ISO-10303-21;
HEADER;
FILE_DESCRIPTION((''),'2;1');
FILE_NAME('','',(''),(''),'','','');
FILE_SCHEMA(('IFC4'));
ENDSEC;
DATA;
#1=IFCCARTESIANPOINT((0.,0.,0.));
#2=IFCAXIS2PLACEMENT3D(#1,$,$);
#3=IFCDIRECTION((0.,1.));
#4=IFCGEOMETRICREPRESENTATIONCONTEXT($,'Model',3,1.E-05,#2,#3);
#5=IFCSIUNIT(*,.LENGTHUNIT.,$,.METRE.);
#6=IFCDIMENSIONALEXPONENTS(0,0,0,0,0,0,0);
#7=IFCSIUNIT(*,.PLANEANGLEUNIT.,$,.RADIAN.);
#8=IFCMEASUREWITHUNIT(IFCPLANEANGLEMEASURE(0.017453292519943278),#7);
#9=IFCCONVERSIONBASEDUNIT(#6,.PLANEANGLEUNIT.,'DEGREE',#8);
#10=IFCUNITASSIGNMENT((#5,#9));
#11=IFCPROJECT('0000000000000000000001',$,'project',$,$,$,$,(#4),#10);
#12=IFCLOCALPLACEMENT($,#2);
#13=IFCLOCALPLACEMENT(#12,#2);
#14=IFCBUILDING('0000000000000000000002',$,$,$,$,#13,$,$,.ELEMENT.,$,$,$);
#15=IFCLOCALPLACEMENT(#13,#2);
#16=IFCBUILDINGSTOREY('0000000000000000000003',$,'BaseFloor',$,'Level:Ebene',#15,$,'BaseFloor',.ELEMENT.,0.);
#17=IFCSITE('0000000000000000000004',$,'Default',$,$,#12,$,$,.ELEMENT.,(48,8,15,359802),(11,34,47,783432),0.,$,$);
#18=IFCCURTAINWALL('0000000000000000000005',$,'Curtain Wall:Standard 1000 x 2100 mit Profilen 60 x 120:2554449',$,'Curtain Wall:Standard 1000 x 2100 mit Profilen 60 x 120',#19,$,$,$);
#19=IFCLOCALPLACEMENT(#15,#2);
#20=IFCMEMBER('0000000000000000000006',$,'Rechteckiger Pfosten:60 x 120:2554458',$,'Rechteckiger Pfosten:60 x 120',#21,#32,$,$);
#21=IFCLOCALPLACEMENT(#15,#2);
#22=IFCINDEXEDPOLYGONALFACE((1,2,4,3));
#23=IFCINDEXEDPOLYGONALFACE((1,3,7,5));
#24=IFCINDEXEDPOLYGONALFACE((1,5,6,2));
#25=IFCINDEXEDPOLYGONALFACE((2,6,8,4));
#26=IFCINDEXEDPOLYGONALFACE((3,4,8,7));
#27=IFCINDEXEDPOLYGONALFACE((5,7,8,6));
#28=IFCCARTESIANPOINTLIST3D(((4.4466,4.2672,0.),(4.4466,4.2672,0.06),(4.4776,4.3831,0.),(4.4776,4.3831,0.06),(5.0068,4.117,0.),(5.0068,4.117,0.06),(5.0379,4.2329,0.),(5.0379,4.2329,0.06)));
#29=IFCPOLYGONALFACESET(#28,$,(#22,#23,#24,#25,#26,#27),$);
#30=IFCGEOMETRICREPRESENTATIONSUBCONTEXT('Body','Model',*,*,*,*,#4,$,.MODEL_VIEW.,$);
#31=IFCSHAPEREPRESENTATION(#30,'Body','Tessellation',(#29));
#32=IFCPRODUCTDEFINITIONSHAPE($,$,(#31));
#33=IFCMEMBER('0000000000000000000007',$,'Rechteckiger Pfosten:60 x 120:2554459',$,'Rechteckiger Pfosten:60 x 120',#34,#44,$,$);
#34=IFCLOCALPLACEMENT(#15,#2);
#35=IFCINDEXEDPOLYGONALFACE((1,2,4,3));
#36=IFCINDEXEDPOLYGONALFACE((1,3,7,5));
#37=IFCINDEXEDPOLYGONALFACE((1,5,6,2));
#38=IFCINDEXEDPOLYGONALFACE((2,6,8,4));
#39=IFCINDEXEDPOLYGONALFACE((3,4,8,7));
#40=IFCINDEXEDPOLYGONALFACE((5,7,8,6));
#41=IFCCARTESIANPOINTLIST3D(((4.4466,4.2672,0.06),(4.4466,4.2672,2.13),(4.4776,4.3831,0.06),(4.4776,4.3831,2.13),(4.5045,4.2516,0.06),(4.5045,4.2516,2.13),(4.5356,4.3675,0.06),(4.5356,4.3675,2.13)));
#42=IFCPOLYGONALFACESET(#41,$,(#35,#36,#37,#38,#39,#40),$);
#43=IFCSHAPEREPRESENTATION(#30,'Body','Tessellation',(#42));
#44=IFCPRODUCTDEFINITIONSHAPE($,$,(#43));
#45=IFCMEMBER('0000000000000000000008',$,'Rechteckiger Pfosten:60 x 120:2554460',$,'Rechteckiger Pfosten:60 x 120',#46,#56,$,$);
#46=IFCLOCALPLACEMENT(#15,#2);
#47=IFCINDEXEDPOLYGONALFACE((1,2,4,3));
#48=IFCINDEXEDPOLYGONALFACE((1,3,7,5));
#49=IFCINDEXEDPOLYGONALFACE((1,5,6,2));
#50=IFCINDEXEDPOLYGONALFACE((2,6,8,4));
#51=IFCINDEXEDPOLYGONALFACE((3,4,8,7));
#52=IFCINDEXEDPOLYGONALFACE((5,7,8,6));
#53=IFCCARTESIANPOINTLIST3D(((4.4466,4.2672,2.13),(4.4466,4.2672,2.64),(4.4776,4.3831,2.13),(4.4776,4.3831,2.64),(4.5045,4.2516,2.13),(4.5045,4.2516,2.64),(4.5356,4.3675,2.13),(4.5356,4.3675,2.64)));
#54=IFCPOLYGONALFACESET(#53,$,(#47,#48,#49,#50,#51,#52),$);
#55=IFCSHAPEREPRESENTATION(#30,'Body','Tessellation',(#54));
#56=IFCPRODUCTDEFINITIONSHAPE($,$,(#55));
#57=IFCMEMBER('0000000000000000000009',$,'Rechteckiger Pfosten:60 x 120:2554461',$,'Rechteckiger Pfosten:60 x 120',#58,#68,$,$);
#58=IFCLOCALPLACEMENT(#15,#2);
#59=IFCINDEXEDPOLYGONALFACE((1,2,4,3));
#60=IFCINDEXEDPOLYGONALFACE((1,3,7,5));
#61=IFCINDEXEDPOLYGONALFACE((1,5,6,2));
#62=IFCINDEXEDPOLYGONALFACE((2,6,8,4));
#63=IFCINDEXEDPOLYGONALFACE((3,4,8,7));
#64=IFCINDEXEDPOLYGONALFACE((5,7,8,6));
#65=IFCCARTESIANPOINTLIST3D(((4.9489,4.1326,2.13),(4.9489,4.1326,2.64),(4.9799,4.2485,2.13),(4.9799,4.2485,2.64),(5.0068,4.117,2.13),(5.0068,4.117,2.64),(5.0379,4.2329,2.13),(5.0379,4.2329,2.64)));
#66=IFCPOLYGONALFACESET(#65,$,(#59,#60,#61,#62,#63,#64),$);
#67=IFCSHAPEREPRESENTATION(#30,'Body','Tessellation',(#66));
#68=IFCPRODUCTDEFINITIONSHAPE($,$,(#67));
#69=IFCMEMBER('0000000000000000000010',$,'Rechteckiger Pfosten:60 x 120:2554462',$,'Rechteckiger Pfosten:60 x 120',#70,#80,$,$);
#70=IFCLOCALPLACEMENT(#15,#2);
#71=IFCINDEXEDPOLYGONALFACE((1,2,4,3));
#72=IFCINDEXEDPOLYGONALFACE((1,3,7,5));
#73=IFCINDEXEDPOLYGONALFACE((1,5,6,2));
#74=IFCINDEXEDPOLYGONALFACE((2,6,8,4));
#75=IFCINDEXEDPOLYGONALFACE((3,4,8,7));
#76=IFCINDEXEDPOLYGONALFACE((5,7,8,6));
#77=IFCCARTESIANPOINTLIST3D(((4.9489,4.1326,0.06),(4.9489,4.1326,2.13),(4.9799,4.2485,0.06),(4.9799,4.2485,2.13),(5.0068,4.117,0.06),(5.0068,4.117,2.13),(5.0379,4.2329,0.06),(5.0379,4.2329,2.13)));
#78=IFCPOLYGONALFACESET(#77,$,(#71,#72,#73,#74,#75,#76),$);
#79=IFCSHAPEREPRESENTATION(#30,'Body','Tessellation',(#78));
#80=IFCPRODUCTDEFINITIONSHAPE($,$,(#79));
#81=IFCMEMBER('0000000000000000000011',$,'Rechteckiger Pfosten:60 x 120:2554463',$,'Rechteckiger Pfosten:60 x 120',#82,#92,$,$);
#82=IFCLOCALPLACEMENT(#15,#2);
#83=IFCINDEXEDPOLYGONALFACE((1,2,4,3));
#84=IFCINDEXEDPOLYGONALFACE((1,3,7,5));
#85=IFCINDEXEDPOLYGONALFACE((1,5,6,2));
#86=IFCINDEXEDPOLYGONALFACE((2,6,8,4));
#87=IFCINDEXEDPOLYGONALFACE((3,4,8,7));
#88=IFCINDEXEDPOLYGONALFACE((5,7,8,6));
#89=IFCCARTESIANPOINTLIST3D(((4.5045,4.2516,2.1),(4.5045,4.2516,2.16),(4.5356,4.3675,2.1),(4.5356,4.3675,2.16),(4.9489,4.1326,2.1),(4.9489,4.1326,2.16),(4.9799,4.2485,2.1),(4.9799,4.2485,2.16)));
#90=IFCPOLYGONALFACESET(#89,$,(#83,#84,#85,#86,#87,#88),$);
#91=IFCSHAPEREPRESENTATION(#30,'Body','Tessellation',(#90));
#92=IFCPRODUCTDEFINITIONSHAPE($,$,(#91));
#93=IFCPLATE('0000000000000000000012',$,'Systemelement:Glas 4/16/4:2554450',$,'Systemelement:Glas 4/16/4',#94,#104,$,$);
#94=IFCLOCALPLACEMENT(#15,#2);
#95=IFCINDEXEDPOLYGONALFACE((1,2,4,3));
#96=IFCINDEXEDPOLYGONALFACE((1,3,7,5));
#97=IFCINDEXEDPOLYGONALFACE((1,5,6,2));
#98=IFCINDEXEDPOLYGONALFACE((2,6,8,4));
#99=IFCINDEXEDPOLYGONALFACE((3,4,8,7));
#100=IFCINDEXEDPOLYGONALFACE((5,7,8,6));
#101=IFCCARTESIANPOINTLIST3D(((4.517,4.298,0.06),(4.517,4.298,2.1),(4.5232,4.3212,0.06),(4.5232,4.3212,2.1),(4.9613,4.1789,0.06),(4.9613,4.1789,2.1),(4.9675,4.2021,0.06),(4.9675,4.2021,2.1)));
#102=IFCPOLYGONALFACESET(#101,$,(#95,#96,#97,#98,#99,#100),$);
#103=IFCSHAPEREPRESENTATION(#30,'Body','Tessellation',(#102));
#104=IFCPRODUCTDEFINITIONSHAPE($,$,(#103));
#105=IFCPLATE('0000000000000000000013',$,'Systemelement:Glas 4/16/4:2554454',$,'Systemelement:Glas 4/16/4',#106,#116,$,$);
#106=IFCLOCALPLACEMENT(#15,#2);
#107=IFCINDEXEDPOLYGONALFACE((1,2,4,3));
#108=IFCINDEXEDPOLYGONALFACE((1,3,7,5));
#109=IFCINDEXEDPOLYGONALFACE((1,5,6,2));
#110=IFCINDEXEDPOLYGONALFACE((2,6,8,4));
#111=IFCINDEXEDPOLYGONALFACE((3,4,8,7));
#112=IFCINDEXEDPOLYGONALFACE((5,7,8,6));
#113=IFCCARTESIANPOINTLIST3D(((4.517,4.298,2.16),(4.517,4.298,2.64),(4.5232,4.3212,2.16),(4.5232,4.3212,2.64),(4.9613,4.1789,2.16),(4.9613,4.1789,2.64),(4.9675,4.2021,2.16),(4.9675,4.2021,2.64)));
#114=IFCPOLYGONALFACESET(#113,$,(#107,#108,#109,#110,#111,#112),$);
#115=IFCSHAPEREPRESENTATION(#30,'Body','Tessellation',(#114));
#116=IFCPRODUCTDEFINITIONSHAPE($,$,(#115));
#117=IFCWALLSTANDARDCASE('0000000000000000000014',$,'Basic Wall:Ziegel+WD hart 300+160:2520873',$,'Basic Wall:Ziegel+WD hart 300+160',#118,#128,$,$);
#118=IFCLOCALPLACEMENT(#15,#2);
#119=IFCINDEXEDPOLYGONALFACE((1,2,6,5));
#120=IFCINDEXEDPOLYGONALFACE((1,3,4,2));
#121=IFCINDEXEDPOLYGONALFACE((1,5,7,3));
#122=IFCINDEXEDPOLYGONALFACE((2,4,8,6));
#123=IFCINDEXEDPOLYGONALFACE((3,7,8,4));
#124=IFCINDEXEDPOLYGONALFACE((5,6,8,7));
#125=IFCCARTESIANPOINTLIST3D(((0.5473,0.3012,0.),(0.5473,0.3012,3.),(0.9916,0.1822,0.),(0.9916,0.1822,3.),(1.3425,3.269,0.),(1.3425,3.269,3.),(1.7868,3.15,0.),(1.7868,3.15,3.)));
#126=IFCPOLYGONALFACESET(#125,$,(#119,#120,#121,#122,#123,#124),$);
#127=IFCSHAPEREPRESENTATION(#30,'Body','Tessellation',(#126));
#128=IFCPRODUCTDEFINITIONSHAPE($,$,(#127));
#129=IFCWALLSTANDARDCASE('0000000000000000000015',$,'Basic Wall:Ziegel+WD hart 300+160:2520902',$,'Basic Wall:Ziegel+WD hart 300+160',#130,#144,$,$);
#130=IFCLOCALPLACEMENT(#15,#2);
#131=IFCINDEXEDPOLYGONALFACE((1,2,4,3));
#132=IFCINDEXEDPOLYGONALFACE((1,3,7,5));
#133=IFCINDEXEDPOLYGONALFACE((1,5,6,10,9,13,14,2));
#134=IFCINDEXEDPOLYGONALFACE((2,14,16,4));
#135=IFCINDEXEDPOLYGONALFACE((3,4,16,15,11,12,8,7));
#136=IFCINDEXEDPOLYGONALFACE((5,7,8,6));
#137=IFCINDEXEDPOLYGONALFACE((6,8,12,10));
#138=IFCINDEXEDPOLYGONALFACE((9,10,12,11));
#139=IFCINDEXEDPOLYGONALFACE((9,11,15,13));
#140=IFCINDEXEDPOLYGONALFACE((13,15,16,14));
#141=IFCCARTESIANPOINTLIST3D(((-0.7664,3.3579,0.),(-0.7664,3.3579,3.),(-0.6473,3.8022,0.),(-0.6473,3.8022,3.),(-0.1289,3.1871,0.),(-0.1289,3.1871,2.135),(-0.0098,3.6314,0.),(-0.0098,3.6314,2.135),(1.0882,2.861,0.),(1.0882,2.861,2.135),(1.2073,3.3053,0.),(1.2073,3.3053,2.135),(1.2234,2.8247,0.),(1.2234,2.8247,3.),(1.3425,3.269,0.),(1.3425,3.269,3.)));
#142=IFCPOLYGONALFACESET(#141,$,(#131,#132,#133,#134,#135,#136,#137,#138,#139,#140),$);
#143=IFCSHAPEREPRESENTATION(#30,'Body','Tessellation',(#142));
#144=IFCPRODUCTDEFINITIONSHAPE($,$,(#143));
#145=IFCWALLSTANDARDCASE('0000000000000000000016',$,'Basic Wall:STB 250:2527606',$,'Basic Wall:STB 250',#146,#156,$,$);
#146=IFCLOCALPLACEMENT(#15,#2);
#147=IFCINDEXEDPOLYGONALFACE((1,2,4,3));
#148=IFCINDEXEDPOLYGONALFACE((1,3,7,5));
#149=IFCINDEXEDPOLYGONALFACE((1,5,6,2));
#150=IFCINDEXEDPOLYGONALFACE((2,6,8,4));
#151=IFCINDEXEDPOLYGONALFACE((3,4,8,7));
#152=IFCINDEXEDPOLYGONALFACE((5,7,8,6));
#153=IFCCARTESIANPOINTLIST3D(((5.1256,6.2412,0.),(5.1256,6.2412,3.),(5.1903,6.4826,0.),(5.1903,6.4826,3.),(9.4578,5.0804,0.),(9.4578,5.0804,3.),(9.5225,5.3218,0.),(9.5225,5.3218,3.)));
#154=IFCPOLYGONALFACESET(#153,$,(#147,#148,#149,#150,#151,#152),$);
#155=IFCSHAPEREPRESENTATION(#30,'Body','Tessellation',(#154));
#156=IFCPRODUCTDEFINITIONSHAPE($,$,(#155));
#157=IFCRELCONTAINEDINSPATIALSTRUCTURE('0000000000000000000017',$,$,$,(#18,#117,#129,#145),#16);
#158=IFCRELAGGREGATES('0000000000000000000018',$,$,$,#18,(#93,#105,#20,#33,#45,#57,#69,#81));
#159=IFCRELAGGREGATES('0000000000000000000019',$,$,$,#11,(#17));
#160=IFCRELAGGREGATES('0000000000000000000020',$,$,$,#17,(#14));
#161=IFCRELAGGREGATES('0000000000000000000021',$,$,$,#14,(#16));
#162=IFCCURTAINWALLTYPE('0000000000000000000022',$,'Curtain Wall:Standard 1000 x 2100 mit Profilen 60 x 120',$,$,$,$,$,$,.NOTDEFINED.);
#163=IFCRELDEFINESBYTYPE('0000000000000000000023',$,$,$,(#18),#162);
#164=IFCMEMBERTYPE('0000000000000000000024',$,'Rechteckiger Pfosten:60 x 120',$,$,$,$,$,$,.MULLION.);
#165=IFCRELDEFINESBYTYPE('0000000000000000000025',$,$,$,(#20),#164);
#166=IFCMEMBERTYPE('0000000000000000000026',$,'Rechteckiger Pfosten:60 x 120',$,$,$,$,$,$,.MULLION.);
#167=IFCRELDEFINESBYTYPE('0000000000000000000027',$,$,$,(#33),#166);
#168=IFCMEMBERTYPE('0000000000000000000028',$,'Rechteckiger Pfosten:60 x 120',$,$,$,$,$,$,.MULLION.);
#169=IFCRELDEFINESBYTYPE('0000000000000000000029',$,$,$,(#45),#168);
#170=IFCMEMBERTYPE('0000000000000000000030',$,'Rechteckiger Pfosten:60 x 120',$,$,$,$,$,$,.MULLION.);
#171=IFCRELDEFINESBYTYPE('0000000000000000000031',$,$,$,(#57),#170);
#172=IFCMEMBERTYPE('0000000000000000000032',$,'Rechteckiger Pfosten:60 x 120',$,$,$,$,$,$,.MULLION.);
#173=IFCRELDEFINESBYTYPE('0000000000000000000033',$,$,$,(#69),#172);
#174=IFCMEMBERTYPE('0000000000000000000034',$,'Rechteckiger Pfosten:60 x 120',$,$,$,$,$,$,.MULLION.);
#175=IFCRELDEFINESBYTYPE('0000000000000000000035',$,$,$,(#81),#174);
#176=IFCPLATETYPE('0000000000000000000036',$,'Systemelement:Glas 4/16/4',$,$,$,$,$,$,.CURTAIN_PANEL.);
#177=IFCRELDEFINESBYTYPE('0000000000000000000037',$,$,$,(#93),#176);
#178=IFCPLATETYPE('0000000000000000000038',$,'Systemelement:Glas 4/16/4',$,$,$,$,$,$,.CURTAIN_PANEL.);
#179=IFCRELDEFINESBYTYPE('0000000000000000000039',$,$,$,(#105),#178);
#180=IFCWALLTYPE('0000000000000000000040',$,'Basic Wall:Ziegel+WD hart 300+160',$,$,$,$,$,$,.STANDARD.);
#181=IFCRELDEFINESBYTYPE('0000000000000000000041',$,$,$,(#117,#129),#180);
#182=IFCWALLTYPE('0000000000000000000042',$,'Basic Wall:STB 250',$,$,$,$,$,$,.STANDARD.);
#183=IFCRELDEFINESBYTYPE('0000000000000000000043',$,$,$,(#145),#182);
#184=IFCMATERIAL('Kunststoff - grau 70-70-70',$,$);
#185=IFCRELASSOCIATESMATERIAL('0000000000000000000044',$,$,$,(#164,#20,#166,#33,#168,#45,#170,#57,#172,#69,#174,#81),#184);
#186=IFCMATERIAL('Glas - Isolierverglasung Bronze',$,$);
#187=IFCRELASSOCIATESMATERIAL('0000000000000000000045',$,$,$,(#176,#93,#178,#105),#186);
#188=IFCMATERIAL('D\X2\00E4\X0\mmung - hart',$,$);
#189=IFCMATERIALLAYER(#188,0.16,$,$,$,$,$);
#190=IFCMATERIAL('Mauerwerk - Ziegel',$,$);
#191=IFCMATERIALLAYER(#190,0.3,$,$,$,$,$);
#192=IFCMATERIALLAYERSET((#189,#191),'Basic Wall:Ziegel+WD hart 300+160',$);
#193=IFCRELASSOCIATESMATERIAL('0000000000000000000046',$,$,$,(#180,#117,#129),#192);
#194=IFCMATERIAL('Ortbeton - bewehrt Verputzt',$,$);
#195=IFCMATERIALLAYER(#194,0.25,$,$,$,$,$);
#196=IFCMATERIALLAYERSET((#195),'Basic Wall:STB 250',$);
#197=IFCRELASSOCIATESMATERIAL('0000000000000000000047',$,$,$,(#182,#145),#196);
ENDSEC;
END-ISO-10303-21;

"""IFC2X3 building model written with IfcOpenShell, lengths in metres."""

from ifc_helpers import new_model, entity, si_unit, converted_unit, direction, frame, frame_2d, origin, origin_2d_with_axis, place, context, subcontext, project, spatial, rectangle, extrude, source, transform, mapped, material, layer, layer_set, layer_usage, type_object, type_shapes, element, aggregate, save


model = new_model("IFC2X3")

# Units and contexts
model_context = context("Model", 3, precision=1e-05, world=origin(), true_north=direction((0.0, 1.0)))
body_context = subcontext(model_context, "Body", "Model", "MODEL_VIEW")
ifc_project = project(units=[si_unit("LENGTHUNIT", "METRE"), converted_unit("PLANEANGLEUNIT", "DEGREE", entity("IfcPlaneAngleMeasure", 0.017453292519943278), si_unit("PLANEANGLEUNIT", "RADIAN"), dimensions=[0, 0, 0, 0, 0, 0, 0])], contexts=[model_context])

# Site, building, storey
site_placement = place(None, origin())
site = spatial("IfcSite", under=ifc_project, at=site_placement, Name="Default", CompositionType="ELEMENT", RefLatitude=(48, 8, 15, 359802), RefLongitude=(11, 34, 47, 783432), RefElevation=0.0)
building_placement = place(site_placement, origin())
building = spatial("IfcBuilding", under=site, at=building_placement, CompositionType="ELEMENT")
storey_placement = place(building_placement, origin())
storey = spatial("IfcBuildingStorey", under=building, at=storey_placement, Name="BaseFloor", ObjectType="Level:Ebene", LongName="BaseFloor", CompositionType="ELEMENT", Elevation=0.0)

# Shared definitions
ifc_material_1 = material(Name="Ortbeton - bewehrt Verputzt")

# Curtain wall, members
curtain_wall_type = type_object("IfcCurtainWallType", Name="Curtain Wall:Standard 1000 x 2100 mit Profilen 60 x 120", PredefinedType="NOTDEFINED")
curtain_wall_placement = place(storey_placement, origin())
curtain_wall = element("IfcCurtainWall", 1, at=curtain_wall_placement, inside=storey, type_object=curtain_wall_type, Name="Curtain Wall:Standard 1000 x 2100 mit Profilen 60 x 120:2554449", ObjectType="Curtain Wall:Standard 1000 x 2100 mit Profilen 60 x 120")
ifc_material_2 = material(Name="Kunststoff - grau 70-70-70")
member_type_1 = type_object("IfcMemberType", Name="Rechteckiger Pfosten:60 x 120", PredefinedType="MULLION", material=ifc_material_2)
shared_shape_1 = source(origin(), body_context, "Body", "SweptSolid", [
    extrude(rectangle(XDim=0.06, YDim=0.12, at=origin_2d_with_axis()), frame((-0.03, 0.0, -0.58), z_axis=(0.0, 0.0, 1.0), x_axis=(-1.0, 0.0, 0.0)), (0.0, 0.0, 1.0), 0.58),
])
type_shapes(member_type_1, [shared_shape_1])
member_1_placement = place(curtain_wall_placement, frame((5.0223, 4.175, 0.0), z_axis=(0.965926, -0.258819, 0.0), x_axis=(0.0, 0.0, -1.0)))
member_1 = element("IfcMember", 2, at=member_1_placement, type_object=member_type_1, material=ifc_material_2, Name="Rechteckiger Pfosten:60 x 120:2554458", ObjectType="Rechteckiger Pfosten:60 x 120", context=body_context, shape_type="MappedRepresentation", body=[
    mapped(shared_shape_1, transform((0.0, 0.0, 0.0), scale=1.0)),
])
member_type_2 = type_object("IfcMemberType", Name="Rechteckiger Pfosten:60 x 120", PredefinedType="MULLION", material=ifc_material_2)
shared_shape_2 = source(origin(), body_context, "Body", "SweptSolid", [
    extrude(rectangle(XDim=0.06, YDim=0.12, at=origin_2d_with_axis()), frame((-0.03, 0.0, -2.07), z_axis=(0.0, 0.0, 1.0), x_axis=(-1.0, 0.0, 0.0)), (0.0, 0.0, 1.0), 2.07),
])
type_shapes(member_type_2, [shared_shape_2])
member_2_placement = place(curtain_wall_placement, frame((4.4621, 4.3251, 0.06), z_axis=(0.0, 0.0, -1.0), x_axis=(-0.965926, 0.258819, 0.0)))
member_2 = element("IfcMember", 3, at=member_2_placement, type_object=member_type_2, material=ifc_material_2, Name="Rechteckiger Pfosten:60 x 120:2554459", ObjectType="Rechteckiger Pfosten:60 x 120", context=body_context, shape_type="MappedRepresentation", body=[
    mapped(shared_shape_2, transform((0.0, 0.0, 0.0), scale=1.0)),
])
member_type_3 = type_object("IfcMemberType", Name="Rechteckiger Pfosten:60 x 120", PredefinedType="MULLION", material=ifc_material_2)
shared_shape_3 = source(origin(), body_context, "Body", "SweptSolid", [
    extrude(rectangle(XDim=0.06, YDim=0.12, at=origin_2d_with_axis()), frame((-0.03, 0.0, -0.51), z_axis=(0.0, 0.0, 1.0), x_axis=(-1.0, 0.0, 0.0)), (0.0, 0.0, 1.0), 0.51),
])
type_shapes(member_type_3, [shared_shape_3])
member_3_placement = place(curtain_wall_placement, frame((4.4621, 4.3251, 2.13), z_axis=(0.0, 0.0, -1.0), x_axis=(-0.965926, 0.258819, 0.0)))
member_3 = element("IfcMember", 4, at=member_3_placement, type_object=member_type_3, material=ifc_material_2, Name="Rechteckiger Pfosten:60 x 120:2554460", ObjectType="Rechteckiger Pfosten:60 x 120", context=body_context, shape_type="MappedRepresentation", body=[
    mapped(shared_shape_3, transform((0.0, 0.0, 0.0), scale=1.0)),
])
member_type_4 = type_object("IfcMemberType", Name="Rechteckiger Pfosten:60 x 120", PredefinedType="MULLION", material=ifc_material_2)
shared_shape_4 = source(origin(), body_context, "Body", "SweptSolid", [
    extrude(rectangle(XDim=0.06, YDim=0.12, at=origin_2d_with_axis()), frame((-0.03, 0.0, -0.51), z_axis=(0.0, 0.0, 1.0), x_axis=(-1.0, 0.0, 0.0)), (0.0, 0.0, 1.0), 0.51),
])
type_shapes(member_type_4, [shared_shape_4])
member_4_placement = place(curtain_wall_placement, frame((5.0223, 4.175, 2.64), z_axis=(0.0, 0.0, 1.0), x_axis=(0.965926, -0.258819, 0.0)))
member_4 = element("IfcMember", 5, at=member_4_placement, type_object=member_type_4, material=ifc_material_2, Name="Rechteckiger Pfosten:60 x 120:2554461", ObjectType="Rechteckiger Pfosten:60 x 120", context=body_context, shape_type="MappedRepresentation", body=[
    mapped(shared_shape_4, transform((0.0, 0.0, 0.0), scale=1.0)),
])
member_type_5 = type_object("IfcMemberType", Name="Rechteckiger Pfosten:60 x 120", PredefinedType="MULLION", material=ifc_material_2)
shared_shape_5 = source(origin(), body_context, "Body", "SweptSolid", [
    extrude(rectangle(XDim=0.06, YDim=0.12, at=origin_2d_with_axis()), frame((-0.03, 0.0, -2.07), z_axis=(0.0, 0.0, 1.0), x_axis=(-1.0, 0.0, 0.0)), (0.0, 0.0, 1.0), 2.07),
])
type_shapes(member_type_5, [shared_shape_5])
member_5_placement = place(curtain_wall_placement, frame((5.0223, 4.175, 2.13), z_axis=(0.0, 0.0, 1.0), x_axis=(0.965926, -0.258819, 0.0)))
member_5 = element("IfcMember", 6, at=member_5_placement, type_object=member_type_5, material=ifc_material_2, Name="Rechteckiger Pfosten:60 x 120:2554462", ObjectType="Rechteckiger Pfosten:60 x 120", context=body_context, shape_type="MappedRepresentation", body=[
    mapped(shared_shape_5, transform((0.0, 0.0, 0.0), scale=1.0)),
])
member_type_6 = type_object("IfcMemberType", Name="Rechteckiger Pfosten:60 x 120", PredefinedType="MULLION", material=ifc_material_2)
shared_shape_6 = source(origin(), body_context, "Body", "SweptSolid", [
    extrude(rectangle(XDim=0.06, YDim=0.12, at=frame_2d((0.0, 0.0), x_axis=(1.0, 0.0))), frame((0.0, 0.0, -0.46), z_axis=(0.0, 0.0, 1.0), x_axis=(-1.0, 0.0, 0.0)), (0.0, 0.0, 1.0), 0.46),
])
type_shapes(member_type_6, [shared_shape_6])
member_6_placement = place(curtain_wall_placement, frame((4.5201, 4.3096, 2.13), z_axis=(-0.965926, 0.258819, 0.0), x_axis=(0.0, 0.0, 1.0)))
member_6 = element("IfcMember", 7, at=member_6_placement, type_object=member_type_6, material=ifc_material_2, Name="Rechteckiger Pfosten:60 x 120:2554463", ObjectType="Rechteckiger Pfosten:60 x 120", context=body_context, shape_type="MappedRepresentation", body=[
    mapped(shared_shape_6, transform((0.0, 0.0, 0.0), scale=1.0)),
])

# Plates
ifc_material_3 = material(Name="Glas - Isolierverglasung Bronze")
plate_type_1 = type_object("IfcPlateType", Name="Systemelement:Glas 4/16/4", PredefinedType="CURTAIN_PANEL", material=ifc_material_3)
shared_shape_7 = source(origin(), body_context, "Body", "SweptSolid", [
    extrude(rectangle(XDim=0.024, YDim=0.46, at=frame_2d((0.0, 0.0), x_axis=(1.0, 0.0))), frame((0.0, 0.0, 0.0), z_axis=(0.0, 0.0, 1.0), x_axis=(0.0, 1.0, 0.0)), (0.0, 0.0, 1.0), 2.04),
])
type_shapes(plate_type_1, [shared_shape_7])
plate_1_placement = place(curtain_wall_placement, frame((4.7422, 4.2501, 0.06), z_axis=(0.0, 0.0, 1.0), x_axis=(-0.965926, 0.258819, 0.0)))
plate_1 = element("IfcPlate", 8, at=plate_1_placement, type_object=plate_type_1, material=ifc_material_3, Name="Systemelement:Glas 4/16/4:2554450", ObjectType="Systemelement:Glas 4/16/4", context=body_context, shape_type="MappedRepresentation", body=[
    mapped(shared_shape_7, transform((0.0, 0.0, 0.0), scale=1.0)),
])
plate_type_2 = type_object("IfcPlateType", Name="Systemelement:Glas 4/16/4", PredefinedType="CURTAIN_PANEL", material=ifc_material_3)
shared_shape_8 = source(origin(), body_context, "Body", "SweptSolid", [
    extrude(rectangle(XDim=0.024, YDim=0.46, at=frame_2d((0.0, 0.0), x_axis=(1.0, 0.0))), frame((0.0, 0.0, 0.0), z_axis=(0.0, 0.0, 1.0), x_axis=(0.0, 1.0, 0.0)), (0.0, 0.0, 1.0), 0.48),
])
type_shapes(plate_type_2, [shared_shape_8])
plate_2_placement = place(curtain_wall_placement, frame((4.7422, 4.2501, 2.16), z_axis=(0.0, 0.0, 1.0), x_axis=(-0.965926, 0.258819, 0.0)))
plate_2 = element("IfcPlate", 9, at=plate_2_placement, type_object=plate_type_2, material=ifc_material_3, Name="Systemelement:Glas 4/16/4:2554454", ObjectType="Systemelement:Glas 4/16/4", context=body_context, shape_type="MappedRepresentation", body=[
    mapped(shared_shape_8, transform((0.0, 0.0, 0.0), scale=1.0)),
])
aggregate(curtain_wall, [plate_1, plate_2, member_1, member_2, member_3, member_4, member_5, member_6])

# Wall
ifc_material_4 = material(Name="Dämmung - hart")
ifc_layer_1 = layer(ifc_material_4, 0.16)
ifc_material_5 = material(Name="Mauerwerk - Ziegel")
ifc_layer_2 = layer(ifc_material_5, 0.3)
ifc_layer_set_1 = layer_set([ifc_layer_1, ifc_layer_2], Name="Basic Wall:Ziegel+WD hart 300+160")
ifc_layer_usage_1 = layer_usage(ifc_layer_set_1, "AXIS2", "NEGATIVE", 0.23)
wall_type_1 = type_object("IfcWallType", Name="Basic Wall:Ziegel+WD hart 300+160", PredefinedType="STANDARD", material=ifc_layer_set_1)
wall_1_placement = place(storey_placement, frame((0.7694, 0.2417, 0.0), z_axis=(0.0, 0.0, 1.0), x_axis=(0.258819, 0.965926, 0.0)))
element("IfcWallStandardCase", 10, at=wall_1_placement, inside=storey, type_object=wall_type_1, material=ifc_layer_usage_1, Name="Basic Wall:Ziegel+WD hart 300+160:2520873", ObjectType="Basic Wall:Ziegel+WD hart 300+160", context=body_context, shape_type="SweptSolid", body=[
    extrude(rectangle(XDim=3.0725, YDim=0.46, at=frame_2d((1.5363, 0.0), x_axis=(-1.0, 0.0))), origin(), (0.0, 0.0, 1.0), 3.0),
])

# Wall, opening
ifc_layer_usage_2 = layer_usage(ifc_layer_set_1, "AXIS2", "NEGATIVE", 0.23)
wall_2_placement = place(storey_placement, frame((1.283, 3.0469, 0.0), z_axis=(0.0, 0.0, 1.0), x_axis=(-0.965926, 0.258819, 0.0)))
wall_2 = element("IfcWallStandardCase", 11, at=wall_2_placement, inside=storey, type_object=wall_type_1, material=ifc_layer_usage_2, Name="Basic Wall:Ziegel+WD hart 300+160:2520902", ObjectType="Basic Wall:Ziegel+WD hart 300+160", context=body_context, shape_type="SweptSolid", body=[
    extrude(rectangle(XDim=2.06, YDim=0.46, at=frame_2d((1.03, 0.0), x_axis=(1.0, 0.0))), origin(), (0.0, 0.0, 1.0), 3.0),
])
opening_1_placement = place(wall_2_placement, frame((1.4, 0.23, -0.18)))
element("IfcOpeningElement", 12, at=opening_1_placement, cuts=wall_2, ObjectType="Opening", context=body_context, shape_type="SweptSolid", body=[
    extrude(rectangle(XDim=2.315, YDim=1.26, at=frame_2d((1.1575, 0.63), x_axis=(-1.0, 0.0))), frame((0.0, 0.0, 0.0), z_axis=(0.0, -1.0, 0.0), x_axis=(0.0, 0.0, 1.0)), (0.0, 0.0, 1.0), 0.46),
])
ifc_layer_3 = layer(ifc_material_1, 0.25)
ifc_layer_set_2 = layer_set([ifc_layer_3], Name="Basic Wall:STB 250")
wall_type_2 = type_object("IfcWallType", Name="Basic Wall:STB 250", PredefinedType="STANDARD", material=ifc_layer_set_2)

# Wall
ifc_layer_usage_3 = layer_usage(ifc_layer_set_2, "AXIS2", "NEGATIVE", 0.125)
wall_3_placement = place(storey_placement, frame((5.158, 6.3619, 0.0), z_axis=(0.0, 0.0, 1.0), x_axis=(0.965926, -0.258819, 0.0)))
element("IfcWallStandardCase", 13, at=wall_3_placement, inside=storey, type_object=wall_type_2, material=ifc_layer_usage_3, Name="Basic Wall:STB 250:2527606", ObjectType="Basic Wall:STB 250", context=body_context, shape_type="SweptSolid", body=[
    extrude(rectangle(XDim=4.485, YDim=0.25, at=frame_2d((2.2425, 0.0), x_axis=(-1.0, 0.0))), origin(), (0.0, 0.0, 1.0), 3.0),
])

save(model, "model.ifc")
